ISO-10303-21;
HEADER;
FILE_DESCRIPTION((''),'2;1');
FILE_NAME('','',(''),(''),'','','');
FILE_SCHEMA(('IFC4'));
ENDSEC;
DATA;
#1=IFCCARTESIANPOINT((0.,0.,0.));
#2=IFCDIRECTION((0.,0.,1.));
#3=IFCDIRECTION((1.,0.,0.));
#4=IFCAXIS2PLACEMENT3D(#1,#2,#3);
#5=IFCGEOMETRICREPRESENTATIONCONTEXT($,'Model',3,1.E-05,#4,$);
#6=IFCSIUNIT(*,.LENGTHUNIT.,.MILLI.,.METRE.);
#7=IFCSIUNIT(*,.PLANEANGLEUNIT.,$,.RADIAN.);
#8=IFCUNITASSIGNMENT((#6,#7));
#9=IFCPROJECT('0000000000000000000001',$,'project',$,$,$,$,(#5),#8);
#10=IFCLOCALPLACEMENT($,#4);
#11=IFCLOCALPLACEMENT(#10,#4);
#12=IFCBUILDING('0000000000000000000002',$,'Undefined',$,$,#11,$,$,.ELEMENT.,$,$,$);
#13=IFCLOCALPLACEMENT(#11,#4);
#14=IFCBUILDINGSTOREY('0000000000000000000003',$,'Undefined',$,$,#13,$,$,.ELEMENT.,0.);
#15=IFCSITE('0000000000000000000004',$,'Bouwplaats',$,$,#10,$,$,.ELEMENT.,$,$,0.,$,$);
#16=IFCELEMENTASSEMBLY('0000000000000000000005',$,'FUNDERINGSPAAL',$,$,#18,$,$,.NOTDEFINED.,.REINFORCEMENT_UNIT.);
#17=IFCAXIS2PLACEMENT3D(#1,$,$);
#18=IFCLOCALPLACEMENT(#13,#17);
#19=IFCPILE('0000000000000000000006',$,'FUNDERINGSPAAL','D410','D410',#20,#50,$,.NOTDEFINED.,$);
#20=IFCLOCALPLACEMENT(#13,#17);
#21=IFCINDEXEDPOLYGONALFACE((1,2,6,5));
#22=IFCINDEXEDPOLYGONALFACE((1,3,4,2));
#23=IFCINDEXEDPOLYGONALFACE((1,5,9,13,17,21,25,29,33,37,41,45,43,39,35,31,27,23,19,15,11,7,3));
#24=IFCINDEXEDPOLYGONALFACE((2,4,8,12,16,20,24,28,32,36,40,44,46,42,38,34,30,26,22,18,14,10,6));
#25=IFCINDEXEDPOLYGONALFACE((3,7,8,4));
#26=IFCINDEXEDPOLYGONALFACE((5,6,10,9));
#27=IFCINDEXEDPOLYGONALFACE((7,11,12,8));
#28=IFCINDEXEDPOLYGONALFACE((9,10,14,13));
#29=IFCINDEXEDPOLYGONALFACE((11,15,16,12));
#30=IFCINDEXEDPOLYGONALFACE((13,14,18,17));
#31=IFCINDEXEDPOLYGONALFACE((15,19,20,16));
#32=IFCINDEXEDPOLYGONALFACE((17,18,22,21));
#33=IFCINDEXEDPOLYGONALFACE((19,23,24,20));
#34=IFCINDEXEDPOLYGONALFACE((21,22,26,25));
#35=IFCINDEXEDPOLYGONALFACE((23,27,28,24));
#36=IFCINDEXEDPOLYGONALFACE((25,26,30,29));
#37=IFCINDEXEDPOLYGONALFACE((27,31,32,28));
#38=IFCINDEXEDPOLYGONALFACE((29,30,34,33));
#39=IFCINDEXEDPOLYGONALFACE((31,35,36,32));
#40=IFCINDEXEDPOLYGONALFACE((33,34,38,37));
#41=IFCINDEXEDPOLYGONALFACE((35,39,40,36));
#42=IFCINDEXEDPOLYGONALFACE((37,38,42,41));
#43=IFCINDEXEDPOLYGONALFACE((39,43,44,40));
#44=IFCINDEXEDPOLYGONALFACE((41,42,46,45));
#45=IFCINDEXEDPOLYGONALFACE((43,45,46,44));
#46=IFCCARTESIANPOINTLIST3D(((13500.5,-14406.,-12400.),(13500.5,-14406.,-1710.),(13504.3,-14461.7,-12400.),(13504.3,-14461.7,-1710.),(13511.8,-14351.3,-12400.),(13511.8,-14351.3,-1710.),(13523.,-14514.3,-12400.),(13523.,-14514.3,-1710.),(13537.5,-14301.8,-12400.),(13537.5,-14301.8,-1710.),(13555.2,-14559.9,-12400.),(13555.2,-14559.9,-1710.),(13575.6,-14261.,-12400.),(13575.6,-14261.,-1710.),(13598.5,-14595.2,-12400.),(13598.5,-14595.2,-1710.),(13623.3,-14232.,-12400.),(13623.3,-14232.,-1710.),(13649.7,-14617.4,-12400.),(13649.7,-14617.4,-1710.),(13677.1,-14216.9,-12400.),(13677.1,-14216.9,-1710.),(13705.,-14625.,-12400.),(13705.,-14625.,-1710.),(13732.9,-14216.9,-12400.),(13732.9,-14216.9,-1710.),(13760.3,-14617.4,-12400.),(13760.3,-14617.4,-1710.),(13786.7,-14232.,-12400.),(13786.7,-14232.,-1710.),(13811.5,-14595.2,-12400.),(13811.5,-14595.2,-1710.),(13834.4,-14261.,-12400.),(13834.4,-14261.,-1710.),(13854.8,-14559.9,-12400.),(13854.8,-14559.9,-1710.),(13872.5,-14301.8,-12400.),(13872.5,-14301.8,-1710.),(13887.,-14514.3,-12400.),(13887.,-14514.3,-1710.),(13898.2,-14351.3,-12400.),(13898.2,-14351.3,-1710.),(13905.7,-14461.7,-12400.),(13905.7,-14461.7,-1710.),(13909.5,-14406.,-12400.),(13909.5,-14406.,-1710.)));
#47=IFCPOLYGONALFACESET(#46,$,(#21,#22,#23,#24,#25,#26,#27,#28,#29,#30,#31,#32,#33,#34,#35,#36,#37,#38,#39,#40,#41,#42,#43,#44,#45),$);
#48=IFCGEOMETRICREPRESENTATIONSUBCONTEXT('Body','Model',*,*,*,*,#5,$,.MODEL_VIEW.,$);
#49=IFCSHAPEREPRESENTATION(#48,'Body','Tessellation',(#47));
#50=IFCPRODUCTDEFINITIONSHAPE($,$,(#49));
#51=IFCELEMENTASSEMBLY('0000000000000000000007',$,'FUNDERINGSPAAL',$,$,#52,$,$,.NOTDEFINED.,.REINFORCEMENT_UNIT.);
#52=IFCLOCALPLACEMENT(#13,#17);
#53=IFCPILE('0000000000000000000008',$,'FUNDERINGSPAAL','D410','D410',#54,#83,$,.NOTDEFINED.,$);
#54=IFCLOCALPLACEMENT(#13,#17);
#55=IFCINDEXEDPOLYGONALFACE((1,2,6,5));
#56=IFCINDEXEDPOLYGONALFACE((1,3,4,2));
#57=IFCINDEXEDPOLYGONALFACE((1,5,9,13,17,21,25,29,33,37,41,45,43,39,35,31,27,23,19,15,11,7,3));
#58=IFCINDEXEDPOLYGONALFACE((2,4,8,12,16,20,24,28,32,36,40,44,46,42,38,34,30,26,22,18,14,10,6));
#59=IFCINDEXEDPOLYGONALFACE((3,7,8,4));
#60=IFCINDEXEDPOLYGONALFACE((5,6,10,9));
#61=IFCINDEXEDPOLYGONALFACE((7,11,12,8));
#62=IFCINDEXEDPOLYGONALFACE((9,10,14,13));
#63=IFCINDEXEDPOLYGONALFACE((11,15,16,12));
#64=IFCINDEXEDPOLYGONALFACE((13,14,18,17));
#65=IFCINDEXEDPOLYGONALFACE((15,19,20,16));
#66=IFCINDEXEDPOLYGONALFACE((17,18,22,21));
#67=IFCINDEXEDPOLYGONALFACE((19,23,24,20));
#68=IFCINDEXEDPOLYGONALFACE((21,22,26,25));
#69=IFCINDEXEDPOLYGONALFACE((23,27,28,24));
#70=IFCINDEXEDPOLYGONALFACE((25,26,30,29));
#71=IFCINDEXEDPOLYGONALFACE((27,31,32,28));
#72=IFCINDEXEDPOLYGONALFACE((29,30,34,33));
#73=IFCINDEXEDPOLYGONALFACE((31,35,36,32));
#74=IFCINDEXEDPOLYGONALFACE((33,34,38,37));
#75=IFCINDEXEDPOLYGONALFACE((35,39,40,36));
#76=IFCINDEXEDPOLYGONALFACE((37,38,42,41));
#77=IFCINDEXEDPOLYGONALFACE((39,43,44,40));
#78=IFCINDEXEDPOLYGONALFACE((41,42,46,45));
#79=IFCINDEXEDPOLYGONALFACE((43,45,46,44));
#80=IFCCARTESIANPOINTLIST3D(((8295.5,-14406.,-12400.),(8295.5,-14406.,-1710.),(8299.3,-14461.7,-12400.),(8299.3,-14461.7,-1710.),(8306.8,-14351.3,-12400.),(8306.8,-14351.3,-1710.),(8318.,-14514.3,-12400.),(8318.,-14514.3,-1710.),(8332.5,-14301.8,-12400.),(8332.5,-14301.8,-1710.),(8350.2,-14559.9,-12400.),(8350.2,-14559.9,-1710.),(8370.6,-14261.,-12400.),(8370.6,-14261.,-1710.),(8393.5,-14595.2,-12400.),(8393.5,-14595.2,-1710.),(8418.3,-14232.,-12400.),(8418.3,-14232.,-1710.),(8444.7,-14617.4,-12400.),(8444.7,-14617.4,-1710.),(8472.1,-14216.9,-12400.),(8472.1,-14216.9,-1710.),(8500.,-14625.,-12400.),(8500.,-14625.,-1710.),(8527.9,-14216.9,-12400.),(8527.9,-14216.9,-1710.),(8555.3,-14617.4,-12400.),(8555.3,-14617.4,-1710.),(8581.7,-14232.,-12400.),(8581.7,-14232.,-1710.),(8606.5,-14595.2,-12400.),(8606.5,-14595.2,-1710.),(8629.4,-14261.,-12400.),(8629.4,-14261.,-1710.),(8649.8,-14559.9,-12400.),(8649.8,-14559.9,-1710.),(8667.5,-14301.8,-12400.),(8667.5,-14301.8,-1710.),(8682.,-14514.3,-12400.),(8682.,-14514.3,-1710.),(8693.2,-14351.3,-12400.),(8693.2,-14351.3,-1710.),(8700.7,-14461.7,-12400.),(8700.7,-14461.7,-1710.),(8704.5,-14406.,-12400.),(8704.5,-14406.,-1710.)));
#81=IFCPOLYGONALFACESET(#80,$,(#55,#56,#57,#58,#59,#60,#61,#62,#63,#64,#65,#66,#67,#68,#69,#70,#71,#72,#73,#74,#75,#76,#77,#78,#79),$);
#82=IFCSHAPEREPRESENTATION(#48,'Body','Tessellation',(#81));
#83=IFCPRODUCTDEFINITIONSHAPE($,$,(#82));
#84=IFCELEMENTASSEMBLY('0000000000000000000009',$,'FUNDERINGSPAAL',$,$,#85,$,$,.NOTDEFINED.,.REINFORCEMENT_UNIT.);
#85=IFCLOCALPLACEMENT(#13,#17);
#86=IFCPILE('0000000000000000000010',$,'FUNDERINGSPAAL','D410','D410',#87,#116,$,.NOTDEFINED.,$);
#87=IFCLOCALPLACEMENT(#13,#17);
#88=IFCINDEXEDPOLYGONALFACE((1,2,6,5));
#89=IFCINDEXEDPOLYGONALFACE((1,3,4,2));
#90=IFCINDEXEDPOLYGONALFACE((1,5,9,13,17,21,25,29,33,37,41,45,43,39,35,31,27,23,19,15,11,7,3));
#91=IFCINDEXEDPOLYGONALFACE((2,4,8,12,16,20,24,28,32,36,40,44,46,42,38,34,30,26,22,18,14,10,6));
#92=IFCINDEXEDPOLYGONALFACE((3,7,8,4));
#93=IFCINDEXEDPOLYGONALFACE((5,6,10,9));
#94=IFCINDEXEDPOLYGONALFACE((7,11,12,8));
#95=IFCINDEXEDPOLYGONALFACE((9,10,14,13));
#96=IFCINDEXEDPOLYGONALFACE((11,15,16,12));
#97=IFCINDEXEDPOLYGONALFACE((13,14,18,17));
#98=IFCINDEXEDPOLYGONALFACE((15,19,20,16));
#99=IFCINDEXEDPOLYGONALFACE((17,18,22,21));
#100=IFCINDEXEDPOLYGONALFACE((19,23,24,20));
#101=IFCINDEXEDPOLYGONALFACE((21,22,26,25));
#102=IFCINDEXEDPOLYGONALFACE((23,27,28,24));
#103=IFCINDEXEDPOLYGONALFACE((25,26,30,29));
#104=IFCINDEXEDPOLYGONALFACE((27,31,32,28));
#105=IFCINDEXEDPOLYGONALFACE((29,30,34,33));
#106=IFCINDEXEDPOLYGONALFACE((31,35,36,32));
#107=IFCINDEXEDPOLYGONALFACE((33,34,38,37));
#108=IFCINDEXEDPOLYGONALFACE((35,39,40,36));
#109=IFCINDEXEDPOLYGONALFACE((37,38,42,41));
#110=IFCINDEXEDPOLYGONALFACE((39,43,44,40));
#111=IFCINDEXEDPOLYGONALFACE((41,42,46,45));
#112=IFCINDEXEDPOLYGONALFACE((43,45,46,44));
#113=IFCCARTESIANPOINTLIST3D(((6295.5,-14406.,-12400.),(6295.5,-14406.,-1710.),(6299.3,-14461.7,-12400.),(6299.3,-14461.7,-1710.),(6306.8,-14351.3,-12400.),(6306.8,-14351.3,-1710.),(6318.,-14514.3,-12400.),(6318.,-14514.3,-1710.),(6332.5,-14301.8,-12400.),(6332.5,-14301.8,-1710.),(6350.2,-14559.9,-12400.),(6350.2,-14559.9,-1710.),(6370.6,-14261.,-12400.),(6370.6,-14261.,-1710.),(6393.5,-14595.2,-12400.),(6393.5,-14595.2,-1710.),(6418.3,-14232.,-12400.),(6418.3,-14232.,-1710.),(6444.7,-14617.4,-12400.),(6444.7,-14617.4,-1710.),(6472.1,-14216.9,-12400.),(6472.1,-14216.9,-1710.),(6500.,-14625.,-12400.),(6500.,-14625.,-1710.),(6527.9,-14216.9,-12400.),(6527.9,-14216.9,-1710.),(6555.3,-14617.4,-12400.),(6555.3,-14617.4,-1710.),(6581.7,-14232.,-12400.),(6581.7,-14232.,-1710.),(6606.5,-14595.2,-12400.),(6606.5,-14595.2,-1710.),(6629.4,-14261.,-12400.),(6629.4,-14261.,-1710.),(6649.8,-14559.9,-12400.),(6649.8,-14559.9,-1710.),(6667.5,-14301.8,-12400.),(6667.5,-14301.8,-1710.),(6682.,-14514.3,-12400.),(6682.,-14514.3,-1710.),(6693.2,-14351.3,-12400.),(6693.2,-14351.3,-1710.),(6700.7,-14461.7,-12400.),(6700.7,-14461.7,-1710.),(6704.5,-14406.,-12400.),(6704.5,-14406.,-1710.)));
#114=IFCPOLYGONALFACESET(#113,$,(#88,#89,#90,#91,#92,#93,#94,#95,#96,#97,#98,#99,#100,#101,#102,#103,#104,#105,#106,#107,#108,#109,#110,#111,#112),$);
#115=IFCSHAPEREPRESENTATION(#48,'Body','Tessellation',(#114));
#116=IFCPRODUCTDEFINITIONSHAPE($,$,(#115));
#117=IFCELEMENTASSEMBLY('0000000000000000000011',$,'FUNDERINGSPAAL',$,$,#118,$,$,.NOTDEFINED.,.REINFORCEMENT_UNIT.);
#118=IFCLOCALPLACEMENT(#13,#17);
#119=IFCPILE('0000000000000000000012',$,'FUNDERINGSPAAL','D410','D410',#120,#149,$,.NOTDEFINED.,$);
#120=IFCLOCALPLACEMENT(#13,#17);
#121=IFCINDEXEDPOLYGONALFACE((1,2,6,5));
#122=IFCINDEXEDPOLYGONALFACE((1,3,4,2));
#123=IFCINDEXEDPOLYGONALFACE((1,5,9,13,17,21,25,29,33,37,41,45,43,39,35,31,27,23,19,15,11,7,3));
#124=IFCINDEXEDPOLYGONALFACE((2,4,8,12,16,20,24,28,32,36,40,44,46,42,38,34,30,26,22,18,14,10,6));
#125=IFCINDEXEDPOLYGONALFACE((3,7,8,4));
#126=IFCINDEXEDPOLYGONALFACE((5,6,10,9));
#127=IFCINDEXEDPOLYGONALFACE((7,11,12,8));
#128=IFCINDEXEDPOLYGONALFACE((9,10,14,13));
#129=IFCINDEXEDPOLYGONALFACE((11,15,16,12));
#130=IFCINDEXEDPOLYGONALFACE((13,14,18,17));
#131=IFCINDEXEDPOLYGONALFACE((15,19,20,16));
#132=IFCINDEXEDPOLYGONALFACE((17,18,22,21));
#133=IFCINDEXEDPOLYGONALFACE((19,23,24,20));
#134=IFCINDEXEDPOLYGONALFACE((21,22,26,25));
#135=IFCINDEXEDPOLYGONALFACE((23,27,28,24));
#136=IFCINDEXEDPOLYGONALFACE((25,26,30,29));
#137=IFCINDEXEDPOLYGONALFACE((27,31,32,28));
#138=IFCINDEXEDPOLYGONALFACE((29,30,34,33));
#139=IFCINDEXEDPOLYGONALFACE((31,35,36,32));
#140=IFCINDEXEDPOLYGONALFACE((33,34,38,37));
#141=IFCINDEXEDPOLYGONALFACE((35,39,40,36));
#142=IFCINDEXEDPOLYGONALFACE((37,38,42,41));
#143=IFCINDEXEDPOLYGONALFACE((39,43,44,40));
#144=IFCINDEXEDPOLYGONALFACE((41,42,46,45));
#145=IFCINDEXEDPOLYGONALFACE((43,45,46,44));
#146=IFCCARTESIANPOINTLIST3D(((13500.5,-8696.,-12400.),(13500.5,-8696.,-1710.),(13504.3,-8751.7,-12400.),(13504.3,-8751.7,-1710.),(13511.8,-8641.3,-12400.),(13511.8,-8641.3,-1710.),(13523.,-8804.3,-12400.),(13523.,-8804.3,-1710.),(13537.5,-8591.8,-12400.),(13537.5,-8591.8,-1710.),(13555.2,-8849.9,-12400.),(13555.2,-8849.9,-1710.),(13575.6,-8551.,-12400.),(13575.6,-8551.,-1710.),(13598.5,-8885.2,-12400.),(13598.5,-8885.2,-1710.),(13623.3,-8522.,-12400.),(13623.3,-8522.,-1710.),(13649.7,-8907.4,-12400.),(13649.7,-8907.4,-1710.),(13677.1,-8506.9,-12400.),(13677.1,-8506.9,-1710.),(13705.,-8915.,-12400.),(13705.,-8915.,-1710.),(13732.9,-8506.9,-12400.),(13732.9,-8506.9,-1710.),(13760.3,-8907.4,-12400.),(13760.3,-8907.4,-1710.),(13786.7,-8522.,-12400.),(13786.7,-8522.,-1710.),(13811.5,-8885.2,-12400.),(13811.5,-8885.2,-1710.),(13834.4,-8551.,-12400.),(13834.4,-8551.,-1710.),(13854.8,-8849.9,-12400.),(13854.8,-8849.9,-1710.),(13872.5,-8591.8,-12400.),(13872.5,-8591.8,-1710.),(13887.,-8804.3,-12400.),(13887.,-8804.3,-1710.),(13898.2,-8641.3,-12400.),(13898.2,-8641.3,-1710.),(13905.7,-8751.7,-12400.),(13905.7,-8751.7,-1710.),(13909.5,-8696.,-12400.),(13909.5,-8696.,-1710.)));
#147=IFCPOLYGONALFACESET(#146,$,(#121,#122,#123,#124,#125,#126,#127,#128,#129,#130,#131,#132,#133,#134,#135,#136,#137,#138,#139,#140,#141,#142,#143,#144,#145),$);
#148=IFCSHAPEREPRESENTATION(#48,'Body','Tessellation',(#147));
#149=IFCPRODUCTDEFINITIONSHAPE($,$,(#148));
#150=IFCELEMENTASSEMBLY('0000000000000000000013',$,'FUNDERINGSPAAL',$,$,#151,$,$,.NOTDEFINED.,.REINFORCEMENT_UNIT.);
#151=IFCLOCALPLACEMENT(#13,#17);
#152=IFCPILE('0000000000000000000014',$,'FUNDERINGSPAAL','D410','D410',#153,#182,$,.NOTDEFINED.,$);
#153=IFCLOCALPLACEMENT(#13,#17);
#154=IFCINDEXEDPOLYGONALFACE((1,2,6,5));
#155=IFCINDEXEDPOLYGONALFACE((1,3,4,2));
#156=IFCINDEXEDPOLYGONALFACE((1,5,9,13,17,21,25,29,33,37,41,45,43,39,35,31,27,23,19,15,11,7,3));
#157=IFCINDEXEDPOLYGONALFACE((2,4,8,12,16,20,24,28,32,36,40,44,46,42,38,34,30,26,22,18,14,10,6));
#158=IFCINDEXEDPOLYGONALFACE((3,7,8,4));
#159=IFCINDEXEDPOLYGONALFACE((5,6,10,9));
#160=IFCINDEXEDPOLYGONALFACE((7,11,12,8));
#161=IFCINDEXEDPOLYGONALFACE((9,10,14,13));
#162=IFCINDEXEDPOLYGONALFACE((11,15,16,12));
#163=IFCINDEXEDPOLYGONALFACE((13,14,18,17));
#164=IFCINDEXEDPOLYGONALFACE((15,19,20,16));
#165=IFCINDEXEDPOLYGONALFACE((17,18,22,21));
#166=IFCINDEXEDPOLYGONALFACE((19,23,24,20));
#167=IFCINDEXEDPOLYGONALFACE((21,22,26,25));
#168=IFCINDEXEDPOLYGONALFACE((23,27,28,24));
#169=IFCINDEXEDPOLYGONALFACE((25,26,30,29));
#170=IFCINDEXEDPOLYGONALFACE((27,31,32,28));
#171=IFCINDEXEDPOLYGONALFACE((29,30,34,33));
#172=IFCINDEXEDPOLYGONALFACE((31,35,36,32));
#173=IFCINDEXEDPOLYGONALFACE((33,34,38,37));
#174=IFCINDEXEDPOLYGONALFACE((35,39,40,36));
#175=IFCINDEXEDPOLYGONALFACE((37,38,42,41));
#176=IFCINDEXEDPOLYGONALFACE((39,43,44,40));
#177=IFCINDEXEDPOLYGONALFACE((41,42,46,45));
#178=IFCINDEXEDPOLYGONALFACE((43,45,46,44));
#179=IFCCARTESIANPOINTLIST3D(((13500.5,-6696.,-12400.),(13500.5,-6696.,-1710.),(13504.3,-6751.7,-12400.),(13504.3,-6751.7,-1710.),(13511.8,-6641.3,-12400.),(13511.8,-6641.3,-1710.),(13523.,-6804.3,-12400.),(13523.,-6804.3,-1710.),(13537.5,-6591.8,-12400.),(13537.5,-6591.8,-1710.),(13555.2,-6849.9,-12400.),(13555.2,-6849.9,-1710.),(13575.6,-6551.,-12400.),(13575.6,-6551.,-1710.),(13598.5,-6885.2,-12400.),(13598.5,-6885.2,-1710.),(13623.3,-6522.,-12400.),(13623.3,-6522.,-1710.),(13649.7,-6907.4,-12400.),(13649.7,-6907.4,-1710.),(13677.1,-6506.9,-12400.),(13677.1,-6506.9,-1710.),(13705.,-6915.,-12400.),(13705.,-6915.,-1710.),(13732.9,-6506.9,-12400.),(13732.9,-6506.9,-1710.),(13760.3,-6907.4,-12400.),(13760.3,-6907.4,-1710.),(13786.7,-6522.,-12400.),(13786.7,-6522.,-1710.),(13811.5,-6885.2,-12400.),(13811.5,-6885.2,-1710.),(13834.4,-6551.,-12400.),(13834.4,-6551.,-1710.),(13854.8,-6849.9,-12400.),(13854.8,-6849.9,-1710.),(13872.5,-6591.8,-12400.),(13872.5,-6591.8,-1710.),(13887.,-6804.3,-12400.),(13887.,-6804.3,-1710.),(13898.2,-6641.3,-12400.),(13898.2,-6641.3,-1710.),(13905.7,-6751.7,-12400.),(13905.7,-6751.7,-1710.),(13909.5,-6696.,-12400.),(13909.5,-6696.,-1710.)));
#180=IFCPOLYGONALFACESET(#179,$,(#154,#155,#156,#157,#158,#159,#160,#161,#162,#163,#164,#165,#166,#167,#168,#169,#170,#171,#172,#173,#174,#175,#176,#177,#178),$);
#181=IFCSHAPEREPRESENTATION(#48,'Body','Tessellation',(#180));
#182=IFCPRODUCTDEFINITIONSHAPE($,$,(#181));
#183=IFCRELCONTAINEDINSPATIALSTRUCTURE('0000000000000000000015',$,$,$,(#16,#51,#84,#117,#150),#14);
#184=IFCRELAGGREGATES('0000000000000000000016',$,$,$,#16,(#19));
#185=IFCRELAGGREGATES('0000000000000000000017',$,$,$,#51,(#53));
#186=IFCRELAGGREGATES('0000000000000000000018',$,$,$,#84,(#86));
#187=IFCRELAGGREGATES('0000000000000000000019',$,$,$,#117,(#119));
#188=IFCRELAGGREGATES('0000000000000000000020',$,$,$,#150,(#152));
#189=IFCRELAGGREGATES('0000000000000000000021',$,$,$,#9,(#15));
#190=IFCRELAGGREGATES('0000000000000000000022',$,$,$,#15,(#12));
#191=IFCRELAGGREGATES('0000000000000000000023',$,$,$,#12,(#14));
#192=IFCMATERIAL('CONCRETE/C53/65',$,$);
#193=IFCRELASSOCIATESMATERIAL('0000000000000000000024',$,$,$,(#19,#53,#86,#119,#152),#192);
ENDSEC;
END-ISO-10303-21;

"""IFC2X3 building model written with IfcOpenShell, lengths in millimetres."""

from ifc_helpers import new_model, si_unit, frame, origin_with_axes, origin_2d_with_axis, place, context, subcontext, project, spatial, circle, extrude, clip, halfspace, material, element, aggregate, save


model = new_model("IFC2X3")

# Units and contexts
model_context = context("Model", 3, precision=1e-05, world=origin_with_axes())
body_context = subcontext(model_context, "Body", "Model", "MODEL_VIEW")
ifc_project = project(units=[si_unit("LENGTHUNIT", "METRE", prefix="MILLI"), si_unit("PLANEANGLEUNIT", "RADIAN")], contexts=[model_context])

# Site, building, storey
site_placement = place(None, origin_with_axes())
site = spatial("IfcSite", under=ifc_project, at=site_placement, Name="Bouwplaats", CompositionType="ELEMENT", RefElevation=0.0)
building_placement = place(site_placement, origin_with_axes())
building = spatial("IfcBuilding", under=site, at=building_placement, Name="Undefined", CompositionType="ELEMENT")
storey_placement = place(building_placement, origin_with_axes())
storey = spatial("IfcBuildingStorey", under=building, at=storey_placement, Name="Undefined", CompositionType="ELEMENT", Elevation=0.0)

# Element assemblies, piles
assembly_1_placement = place(storey_placement, origin_with_axes())
assembly_1 = element("IfcElementAssembly", 1, at=assembly_1_placement, inside=storey, Name="FUNDERINGSPAAL", AssemblyPlace="NOTDEFINED", PredefinedType="REINFORCEMENT_UNIT")
ifc_material_1 = material(Name="CONCRETE/C53/65")
pile_1_placement = place(assembly_1_placement, frame((13705.0, -14420.0, -1710.0), z_axis=(1.0, 0.0, 0.0), x_axis=(0.0, 0.0, -1.0)))
pile_1 = element("IfcPile", 2, at=pile_1_placement, material=ifc_material_1, Name="FUNDERINGSPAAL", Description="D410", ObjectType="D410", PredefinedType="NOTDEFINED", context=body_context, shape_type="Clipping", body=[
    clip(extrude(circle(Radius=205.0, at=origin_2d_with_axis()), frame((10690.0, 0.0, 0.0), z_axis=(-1.0, 0.0, 0.0), x_axis=(0.0, -1.0, 0.0)), (0.0, 0.0, 1.0), 10690.0), halfspace(frame((0.0, 205.0, -205.0), z_axis=(-1.0, 0.0, 0.0), x_axis=(0.0, 0.0, 1.0)), False)),
])
aggregate(assembly_1, [pile_1])
assembly_2_placement = place(storey_placement, origin_with_axes())
assembly_2 = element("IfcElementAssembly", 3, at=assembly_2_placement, inside=storey, Name="FUNDERINGSPAAL", AssemblyPlace="NOTDEFINED", PredefinedType="REINFORCEMENT_UNIT")
pile_2_placement = place(assembly_2_placement, frame((8500.0, -14420.0, -1710.0), z_axis=(1.0, 0.0, 0.0), x_axis=(0.0, 0.0, -1.0)))
pile_2 = element("IfcPile", 4, at=pile_2_placement, material=ifc_material_1, Name="FUNDERINGSPAAL", Description="D410", ObjectType="D410", PredefinedType="NOTDEFINED", context=body_context, shape_type="Clipping", body=[
    clip(extrude(circle(Radius=205.0, at=origin_2d_with_axis()), frame((10690.0, 0.0, 0.0), z_axis=(-1.0, 0.0, 0.0), x_axis=(0.0, -1.0, 0.0)), (0.0, 0.0, 1.0), 10690.0), halfspace(frame((0.0, 205.0, -205.0), z_axis=(-1.0, 0.0, 0.0), x_axis=(0.0, 0.0, 1.0)), False)),
])
aggregate(assembly_2, [pile_2])
assembly_3_placement = place(storey_placement, origin_with_axes())
assembly_3 = element("IfcElementAssembly", 5, at=assembly_3_placement, inside=storey, Name="FUNDERINGSPAAL", AssemblyPlace="NOTDEFINED", PredefinedType="REINFORCEMENT_UNIT")
pile_3_placement = place(assembly_3_placement, frame((6500.0, -14420.0, -1710.0), z_axis=(1.0, 0.0, 0.0), x_axis=(0.0, 0.0, -1.0)))
pile_3 = element("IfcPile", 6, at=pile_3_placement, material=ifc_material_1, Name="FUNDERINGSPAAL", Description="D410", ObjectType="D410", PredefinedType="NOTDEFINED", context=body_context, shape_type="Clipping", body=[
    clip(extrude(circle(Radius=205.0, at=origin_2d_with_axis()), frame((10690.0, 0.0, 0.0), z_axis=(-1.0, 0.0, 0.0), x_axis=(0.0, -1.0, 0.0)), (0.0, 0.0, 1.0), 10690.0), halfspace(frame((0.0, 205.0, -205.0), z_axis=(-1.0, 0.0, 0.0), x_axis=(0.0, 0.0, 1.0)), False)),
])
aggregate(assembly_3, [pile_3])
assembly_4_placement = place(storey_placement, origin_with_axes())
assembly_4 = element("IfcElementAssembly", 7, at=assembly_4_placement, inside=storey, Name="FUNDERINGSPAAL", AssemblyPlace="NOTDEFINED", PredefinedType="REINFORCEMENT_UNIT")
pile_4_placement = place(assembly_4_placement, frame((13705.0, -8710.0, -1710.0), z_axis=(1.0, 0.0, 0.0), x_axis=(0.0, 0.0, -1.0)))
pile_4 = element("IfcPile", 8, at=pile_4_placement, material=ifc_material_1, Name="FUNDERINGSPAAL", Description="D410", ObjectType="D410", PredefinedType="NOTDEFINED", context=body_context, shape_type="Clipping", body=[
    clip(extrude(circle(Radius=205.0, at=origin_2d_with_axis()), frame((10690.0, 0.0, 0.0), z_axis=(-1.0, 0.0, 0.0), x_axis=(0.0, -1.0, 0.0)), (0.0, 0.0, 1.0), 10690.0), halfspace(frame((0.0, 205.0, -205.0), z_axis=(-1.0, 0.0, 0.0), x_axis=(0.0, 0.0, 1.0)), False)),
])
aggregate(assembly_4, [pile_4])
assembly_5_placement = place(storey_placement, origin_with_axes())
assembly_5 = element("IfcElementAssembly", 9, at=assembly_5_placement, inside=storey, Name="FUNDERINGSPAAL", AssemblyPlace="NOTDEFINED", PredefinedType="REINFORCEMENT_UNIT")
pile_5_placement = place(assembly_5_placement, frame((13705.0, -6710.0, -1710.0), z_axis=(1.0, 0.0, 0.0), x_axis=(0.0, 0.0, -1.0)))
pile_5 = element("IfcPile", 10, at=pile_5_placement, material=ifc_material_1, Name="FUNDERINGSPAAL", Description="D410", ObjectType="D410", PredefinedType="NOTDEFINED", context=body_context, shape_type="Clipping", body=[
    clip(extrude(circle(Radius=205.0, at=origin_2d_with_axis()), frame((10690.0, 0.0, 0.0), z_axis=(-1.0, 0.0, 0.0), x_axis=(0.0, -1.0, 0.0)), (0.0, 0.0, 1.0), 10690.0), halfspace(frame((0.0, 205.0, -205.0), z_axis=(-1.0, 0.0, 0.0), x_axis=(0.0, 0.0, 1.0)), False)),
])
aggregate(assembly_5, [pile_5])

save(model, "model.ifc")
